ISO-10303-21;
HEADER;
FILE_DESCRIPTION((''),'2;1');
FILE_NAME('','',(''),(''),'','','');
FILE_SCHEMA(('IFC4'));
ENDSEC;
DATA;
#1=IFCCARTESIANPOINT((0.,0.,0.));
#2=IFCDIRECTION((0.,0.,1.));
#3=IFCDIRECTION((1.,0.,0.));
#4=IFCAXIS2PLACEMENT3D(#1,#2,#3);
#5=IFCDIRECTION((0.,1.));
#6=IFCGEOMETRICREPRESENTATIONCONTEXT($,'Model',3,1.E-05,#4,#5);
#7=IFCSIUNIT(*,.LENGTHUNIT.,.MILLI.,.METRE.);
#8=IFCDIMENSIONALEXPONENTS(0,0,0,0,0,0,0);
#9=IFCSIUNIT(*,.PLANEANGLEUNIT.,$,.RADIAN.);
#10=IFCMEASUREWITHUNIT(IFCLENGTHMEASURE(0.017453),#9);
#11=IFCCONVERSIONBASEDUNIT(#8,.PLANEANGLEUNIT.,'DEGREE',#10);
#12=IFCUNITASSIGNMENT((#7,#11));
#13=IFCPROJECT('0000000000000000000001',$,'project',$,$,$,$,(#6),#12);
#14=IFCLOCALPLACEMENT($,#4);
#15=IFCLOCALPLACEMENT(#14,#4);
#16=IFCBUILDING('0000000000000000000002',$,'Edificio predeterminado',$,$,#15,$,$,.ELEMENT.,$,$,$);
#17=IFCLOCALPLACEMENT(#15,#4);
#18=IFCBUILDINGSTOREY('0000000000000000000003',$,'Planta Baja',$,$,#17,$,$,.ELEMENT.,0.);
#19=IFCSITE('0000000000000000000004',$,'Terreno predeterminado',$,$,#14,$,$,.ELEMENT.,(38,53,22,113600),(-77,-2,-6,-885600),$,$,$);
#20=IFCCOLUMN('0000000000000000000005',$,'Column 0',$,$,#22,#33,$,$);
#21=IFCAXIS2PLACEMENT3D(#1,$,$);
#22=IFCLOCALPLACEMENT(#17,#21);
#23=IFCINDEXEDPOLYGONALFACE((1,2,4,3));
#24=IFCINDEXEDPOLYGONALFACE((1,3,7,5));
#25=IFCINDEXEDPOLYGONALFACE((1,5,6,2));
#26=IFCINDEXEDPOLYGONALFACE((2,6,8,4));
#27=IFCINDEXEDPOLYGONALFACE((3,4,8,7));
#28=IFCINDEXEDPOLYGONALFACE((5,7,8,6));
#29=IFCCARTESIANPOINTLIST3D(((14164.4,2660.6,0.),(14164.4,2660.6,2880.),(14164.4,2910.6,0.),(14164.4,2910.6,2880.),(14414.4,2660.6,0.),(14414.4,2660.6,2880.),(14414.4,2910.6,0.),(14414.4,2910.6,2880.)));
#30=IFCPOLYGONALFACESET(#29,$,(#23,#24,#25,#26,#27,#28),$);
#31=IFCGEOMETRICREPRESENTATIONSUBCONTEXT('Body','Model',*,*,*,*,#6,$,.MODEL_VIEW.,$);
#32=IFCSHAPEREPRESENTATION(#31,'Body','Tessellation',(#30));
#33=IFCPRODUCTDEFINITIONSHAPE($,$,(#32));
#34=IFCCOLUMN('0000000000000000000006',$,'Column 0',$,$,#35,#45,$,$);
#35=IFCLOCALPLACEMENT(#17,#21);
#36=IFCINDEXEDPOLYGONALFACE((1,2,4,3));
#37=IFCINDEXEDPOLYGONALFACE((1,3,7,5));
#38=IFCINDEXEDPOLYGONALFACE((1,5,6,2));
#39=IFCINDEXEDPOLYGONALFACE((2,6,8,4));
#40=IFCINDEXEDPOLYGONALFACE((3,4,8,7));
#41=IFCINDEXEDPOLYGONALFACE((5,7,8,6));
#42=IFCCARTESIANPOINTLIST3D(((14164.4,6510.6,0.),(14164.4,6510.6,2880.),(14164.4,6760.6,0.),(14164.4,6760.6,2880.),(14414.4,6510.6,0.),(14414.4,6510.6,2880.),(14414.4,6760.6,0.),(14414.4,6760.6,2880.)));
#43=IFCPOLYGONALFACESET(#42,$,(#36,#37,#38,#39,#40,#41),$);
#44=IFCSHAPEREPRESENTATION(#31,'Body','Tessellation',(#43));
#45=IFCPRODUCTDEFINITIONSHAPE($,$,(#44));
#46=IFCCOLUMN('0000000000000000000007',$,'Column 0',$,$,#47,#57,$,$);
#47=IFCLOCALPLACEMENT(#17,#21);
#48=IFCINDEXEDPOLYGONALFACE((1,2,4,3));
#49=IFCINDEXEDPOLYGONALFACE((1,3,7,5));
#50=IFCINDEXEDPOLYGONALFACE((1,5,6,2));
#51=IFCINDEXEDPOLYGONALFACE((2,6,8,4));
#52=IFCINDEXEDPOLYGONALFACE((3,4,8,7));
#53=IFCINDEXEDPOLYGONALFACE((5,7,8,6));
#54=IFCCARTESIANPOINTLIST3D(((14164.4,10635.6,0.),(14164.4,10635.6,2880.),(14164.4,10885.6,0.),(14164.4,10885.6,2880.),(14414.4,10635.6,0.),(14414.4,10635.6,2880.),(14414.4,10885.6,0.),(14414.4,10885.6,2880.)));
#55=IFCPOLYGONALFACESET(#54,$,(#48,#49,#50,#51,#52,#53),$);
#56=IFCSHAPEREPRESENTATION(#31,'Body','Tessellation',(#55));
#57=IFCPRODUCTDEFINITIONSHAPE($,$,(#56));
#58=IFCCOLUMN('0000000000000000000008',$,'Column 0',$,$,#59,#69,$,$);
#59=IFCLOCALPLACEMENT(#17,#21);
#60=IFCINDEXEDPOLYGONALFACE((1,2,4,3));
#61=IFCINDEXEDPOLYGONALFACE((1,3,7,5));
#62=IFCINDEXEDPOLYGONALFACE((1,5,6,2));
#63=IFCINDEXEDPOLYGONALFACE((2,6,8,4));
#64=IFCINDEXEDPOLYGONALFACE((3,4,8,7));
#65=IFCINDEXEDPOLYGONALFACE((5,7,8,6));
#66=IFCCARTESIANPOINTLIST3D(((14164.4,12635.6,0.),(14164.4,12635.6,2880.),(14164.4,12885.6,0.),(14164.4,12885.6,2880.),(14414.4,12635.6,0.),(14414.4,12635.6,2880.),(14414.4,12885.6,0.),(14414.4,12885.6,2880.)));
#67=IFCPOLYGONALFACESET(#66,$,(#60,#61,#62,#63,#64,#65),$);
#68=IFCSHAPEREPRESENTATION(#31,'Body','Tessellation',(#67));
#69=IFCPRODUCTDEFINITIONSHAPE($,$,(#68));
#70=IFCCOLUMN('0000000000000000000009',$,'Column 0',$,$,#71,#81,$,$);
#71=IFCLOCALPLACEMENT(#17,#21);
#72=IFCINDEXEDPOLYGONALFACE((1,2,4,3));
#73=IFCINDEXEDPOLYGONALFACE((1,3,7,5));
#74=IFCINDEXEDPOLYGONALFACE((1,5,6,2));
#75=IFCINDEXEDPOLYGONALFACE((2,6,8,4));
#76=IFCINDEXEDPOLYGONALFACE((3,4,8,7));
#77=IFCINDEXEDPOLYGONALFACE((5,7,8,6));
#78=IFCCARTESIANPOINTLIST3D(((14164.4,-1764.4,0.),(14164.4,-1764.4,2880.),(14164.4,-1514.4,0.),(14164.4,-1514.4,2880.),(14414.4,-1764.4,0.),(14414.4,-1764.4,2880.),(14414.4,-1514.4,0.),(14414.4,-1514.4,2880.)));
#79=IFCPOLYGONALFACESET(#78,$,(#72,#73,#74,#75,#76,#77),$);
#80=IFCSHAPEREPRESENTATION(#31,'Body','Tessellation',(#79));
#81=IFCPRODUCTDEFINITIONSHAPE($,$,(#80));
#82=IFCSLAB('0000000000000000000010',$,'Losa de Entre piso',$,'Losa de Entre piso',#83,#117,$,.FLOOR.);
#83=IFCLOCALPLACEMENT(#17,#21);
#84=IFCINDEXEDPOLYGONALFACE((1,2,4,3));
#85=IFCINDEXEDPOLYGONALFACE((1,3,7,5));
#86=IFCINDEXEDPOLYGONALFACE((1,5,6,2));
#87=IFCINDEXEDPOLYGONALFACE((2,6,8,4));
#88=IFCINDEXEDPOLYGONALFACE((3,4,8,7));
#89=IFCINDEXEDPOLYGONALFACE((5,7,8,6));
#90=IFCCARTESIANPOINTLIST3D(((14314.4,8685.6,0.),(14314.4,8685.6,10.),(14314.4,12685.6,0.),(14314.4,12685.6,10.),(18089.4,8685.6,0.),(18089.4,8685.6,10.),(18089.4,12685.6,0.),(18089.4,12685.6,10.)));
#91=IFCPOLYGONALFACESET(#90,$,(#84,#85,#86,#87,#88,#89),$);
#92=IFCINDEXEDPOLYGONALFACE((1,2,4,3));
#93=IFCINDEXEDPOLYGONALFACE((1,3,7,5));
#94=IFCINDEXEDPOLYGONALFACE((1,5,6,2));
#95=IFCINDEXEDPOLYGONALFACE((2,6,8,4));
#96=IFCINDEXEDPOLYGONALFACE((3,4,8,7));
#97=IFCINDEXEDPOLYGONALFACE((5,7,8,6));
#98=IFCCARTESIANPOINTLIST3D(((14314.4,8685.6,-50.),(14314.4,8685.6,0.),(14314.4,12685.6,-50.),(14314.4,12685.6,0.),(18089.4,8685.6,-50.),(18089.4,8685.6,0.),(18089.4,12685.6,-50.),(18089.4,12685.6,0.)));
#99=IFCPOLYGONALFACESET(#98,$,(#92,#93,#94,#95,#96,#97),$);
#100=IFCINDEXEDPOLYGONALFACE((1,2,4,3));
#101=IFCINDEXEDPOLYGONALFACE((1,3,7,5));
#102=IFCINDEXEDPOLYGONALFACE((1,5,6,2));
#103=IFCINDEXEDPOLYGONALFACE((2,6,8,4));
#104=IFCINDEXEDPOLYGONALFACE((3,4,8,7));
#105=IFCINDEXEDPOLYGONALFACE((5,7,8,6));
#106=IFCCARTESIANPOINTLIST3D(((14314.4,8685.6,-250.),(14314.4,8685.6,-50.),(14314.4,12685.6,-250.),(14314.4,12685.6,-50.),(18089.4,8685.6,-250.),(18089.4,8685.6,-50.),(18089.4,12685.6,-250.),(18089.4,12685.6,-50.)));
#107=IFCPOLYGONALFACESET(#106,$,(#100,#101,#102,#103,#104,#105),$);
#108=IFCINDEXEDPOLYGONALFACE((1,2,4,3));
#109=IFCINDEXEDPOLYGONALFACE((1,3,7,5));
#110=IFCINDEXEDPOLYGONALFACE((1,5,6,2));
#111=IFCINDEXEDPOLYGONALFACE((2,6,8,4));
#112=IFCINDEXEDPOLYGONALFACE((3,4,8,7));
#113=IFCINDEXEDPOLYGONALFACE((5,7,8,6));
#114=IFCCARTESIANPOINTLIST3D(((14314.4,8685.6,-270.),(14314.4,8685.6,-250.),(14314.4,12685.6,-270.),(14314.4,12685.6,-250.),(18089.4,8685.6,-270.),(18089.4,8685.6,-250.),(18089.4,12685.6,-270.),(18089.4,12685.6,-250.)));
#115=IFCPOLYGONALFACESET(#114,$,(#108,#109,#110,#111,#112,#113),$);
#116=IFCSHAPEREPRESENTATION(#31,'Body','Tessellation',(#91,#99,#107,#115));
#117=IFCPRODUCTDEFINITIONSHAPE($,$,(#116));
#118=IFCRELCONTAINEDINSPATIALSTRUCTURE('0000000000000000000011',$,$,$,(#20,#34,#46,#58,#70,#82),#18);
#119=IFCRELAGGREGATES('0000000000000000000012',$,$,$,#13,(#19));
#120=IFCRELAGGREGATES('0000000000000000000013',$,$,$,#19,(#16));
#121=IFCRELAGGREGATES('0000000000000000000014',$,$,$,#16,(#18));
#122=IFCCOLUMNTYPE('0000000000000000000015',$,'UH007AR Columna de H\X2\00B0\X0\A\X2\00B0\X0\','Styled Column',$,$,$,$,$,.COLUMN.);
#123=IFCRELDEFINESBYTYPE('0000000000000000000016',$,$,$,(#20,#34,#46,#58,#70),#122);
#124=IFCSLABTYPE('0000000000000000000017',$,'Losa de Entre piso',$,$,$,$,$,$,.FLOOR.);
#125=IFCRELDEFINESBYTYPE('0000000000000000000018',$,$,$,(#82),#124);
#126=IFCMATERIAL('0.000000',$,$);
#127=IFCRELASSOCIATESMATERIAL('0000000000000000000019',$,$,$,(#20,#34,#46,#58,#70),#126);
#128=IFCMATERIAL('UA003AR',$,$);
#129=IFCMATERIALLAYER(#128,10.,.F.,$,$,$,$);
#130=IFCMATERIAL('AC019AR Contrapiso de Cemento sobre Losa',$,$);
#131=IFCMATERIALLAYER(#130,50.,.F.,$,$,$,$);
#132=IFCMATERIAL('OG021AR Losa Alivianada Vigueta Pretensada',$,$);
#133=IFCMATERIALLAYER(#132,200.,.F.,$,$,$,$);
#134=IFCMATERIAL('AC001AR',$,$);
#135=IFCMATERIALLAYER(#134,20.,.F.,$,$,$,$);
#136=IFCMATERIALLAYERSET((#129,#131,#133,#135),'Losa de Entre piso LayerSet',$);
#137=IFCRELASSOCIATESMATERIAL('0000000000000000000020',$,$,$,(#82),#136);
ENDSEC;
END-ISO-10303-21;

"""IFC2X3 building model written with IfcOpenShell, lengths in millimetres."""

from ifc_helpers import new_model, entity, si_unit, converted_unit, direction, frame, origin_with_axes, place, context, subcontext, project, spatial, polyline, outline, extrude, material, layer, layer_set, layer_usage, type_object, element, save


model = new_model("IFC2X3")

# Units and contexts
model_context = context("Model", 3, precision=1e-05, world=origin_with_axes(), true_north=direction((0.0, 1.0)))
body_context = subcontext(model_context, "Body", "Model", "MODEL_VIEW")
ifc_project = project(units=[si_unit("LENGTHUNIT", "METRE", prefix="MILLI"), converted_unit("PLANEANGLEUNIT", "DEGREE", entity("IfcLengthMeasure", 0.017453), si_unit("PLANEANGLEUNIT", "RADIAN"), dimensions=[0, 0, 0, 0, 0, 0, 0])], contexts=[model_context])

# Site, building, storey
site_placement = place(None, origin_with_axes())
site = spatial("IfcSite", under=ifc_project, at=site_placement, Name="Terreno predeterminado", CompositionType="ELEMENT", RefLatitude=(38, 53, 22, 113600), RefLongitude=(-77, -2, -6, -885600))
building_placement = place(site_placement, origin_with_axes())
building = spatial("IfcBuilding", under=site, at=building_placement, Name="Edificio predeterminado", CompositionType="ELEMENT")
storey_placement = place(building_placement, origin_with_axes())
storey = spatial("IfcBuildingStorey", under=building, at=storey_placement, Name="Planta Baja", CompositionType="ELEMENT", Elevation=0.0)

# Columns
ifc_material_1 = material(Name="0.000000")
column_type = type_object("IfcColumnType", Name="UH007AR Columna de H°A°", Description="Styled Column", PredefinedType="COLUMN")
for number, where, z_axis, x_axis, name in (
    (1, (14289.4, 2785.6, 0.0), (0.0, 0.0, 1.0), (1.0, 0.0, 0.0), "Column 0"),
    (2, (14289.4, 6635.6, 0.0), (0.0, 0.0, 1.0), (1.0, 0.0, 0.0), "Column 0"),
    (3, (14289.4, 10760.6, 0.0), (0.0, 0.0, 1.0), (1.0, 0.0, 0.0), "Column 0"),
    (4, (14289.4, 12760.6, 0.0), (0.0, 0.0, 1.0), (1.0, 0.0, 0.0), "Column 0"),
    (5, (14289.4, -1639.4, 0.0), (0.0, 0.0, 1.0), (1.0, 0.0, 0.0), "Column 0"),
):
    element("IfcColumn", number, at=place(storey_placement, frame(where, z_axis=z_axis, x_axis=x_axis)), inside=storey, type_object=column_type, material=ifc_material_1, Name=name, context=body_context, shape_type="SweptSolid", body=[
        extrude(outline(polyline([(-125.0, -125.0), (125.0, -125.0), (125.0, 125.0), (-125.0, 125.0), (-125.0, -125.0)])), origin_with_axes(), (0.0, 0.0, 1.0), 2880.0),
    ])

# Slab
ifc_material_2 = material(Name="UA003AR")
ifc_layer_1 = layer(ifc_material_2, 10.0, ventilated=False)
ifc_material_3 = material(Name="AC019AR Contrapiso de Cemento sobre Losa")
ifc_layer_2 = layer(ifc_material_3, 50.0, ventilated=False)
ifc_material_4 = material(Name="OG021AR Losa Alivianada Vigueta Pretensada")
ifc_layer_3 = layer(ifc_material_4, 200.0, ventilated=False)
ifc_material_5 = material(Name="AC001AR")
ifc_layer_4 = layer(ifc_material_5, 20.0, ventilated=False)
ifc_layer_set_1 = layer_set([ifc_layer_1, ifc_layer_2, ifc_layer_3, ifc_layer_4], Name="Losa de Entre piso LayerSet")
ifc_layer_usage_1 = layer_usage(ifc_layer_set_1, "AXIS3", "NEGATIVE", 0.0)
slab_type = type_object("IfcSlabType", Name="Losa de Entre piso", PredefinedType="FLOOR")
slab_1_placement = place(storey_placement, origin_with_axes())
element("IfcSlab", 6, at=slab_1_placement, inside=storey, type_object=slab_type, material=ifc_layer_usage_1, Name="Losa de Entre piso", ObjectType="Losa de Entre piso", PredefinedType="FLOOR", context=body_context, shape_type="SweptSolid", body=[
    extrude(outline(polyline([(0.0, 4000.0), (3775.0, 4000.0), (3775.0, 0.0), (0.0, 0.0), (0.0, 4000.0)])), frame((14314.4, 12685.6, 0.0), z_axis=(0.0, 0.0, -1.0), x_axis=(1.0, 0.0, 0.0)), (0.0, 0.0, -1.0), 10.0),
    extrude(outline(polyline([(0.0, 4000.0), (3775.0, 4000.0), (3775.0, 0.0), (0.0, 0.0), (0.0, 4000.0)])), frame((14314.4, 12685.6, -50.0), z_axis=(0.0, 0.0, -1.0), x_axis=(1.0, 0.0, 0.0)), (0.0, 0.0, -1.0), 50.0),
    extrude(outline(polyline([(0.0, 4000.0), (3775.0, 4000.0), (3775.0, 0.0), (0.0, 0.0), (0.0, 4000.0)])), frame((14314.4, 12685.6, -250.0), z_axis=(0.0, 0.0, -1.0), x_axis=(1.0, 0.0, 0.0)), (0.0, 0.0, -1.0), 200.0),
    extrude(outline(polyline([(0.0, 4000.0), (3775.0, 4000.0), (3775.0, 0.0), (0.0, 0.0), (0.0, 4000.0)])), frame((14314.4, 12685.6, -270.0), z_axis=(0.0, 0.0, -1.0), x_axis=(1.0, 0.0, 0.0)), (0.0, 0.0, -1.0), 20.0),
])

save(model, "model.ifc")
